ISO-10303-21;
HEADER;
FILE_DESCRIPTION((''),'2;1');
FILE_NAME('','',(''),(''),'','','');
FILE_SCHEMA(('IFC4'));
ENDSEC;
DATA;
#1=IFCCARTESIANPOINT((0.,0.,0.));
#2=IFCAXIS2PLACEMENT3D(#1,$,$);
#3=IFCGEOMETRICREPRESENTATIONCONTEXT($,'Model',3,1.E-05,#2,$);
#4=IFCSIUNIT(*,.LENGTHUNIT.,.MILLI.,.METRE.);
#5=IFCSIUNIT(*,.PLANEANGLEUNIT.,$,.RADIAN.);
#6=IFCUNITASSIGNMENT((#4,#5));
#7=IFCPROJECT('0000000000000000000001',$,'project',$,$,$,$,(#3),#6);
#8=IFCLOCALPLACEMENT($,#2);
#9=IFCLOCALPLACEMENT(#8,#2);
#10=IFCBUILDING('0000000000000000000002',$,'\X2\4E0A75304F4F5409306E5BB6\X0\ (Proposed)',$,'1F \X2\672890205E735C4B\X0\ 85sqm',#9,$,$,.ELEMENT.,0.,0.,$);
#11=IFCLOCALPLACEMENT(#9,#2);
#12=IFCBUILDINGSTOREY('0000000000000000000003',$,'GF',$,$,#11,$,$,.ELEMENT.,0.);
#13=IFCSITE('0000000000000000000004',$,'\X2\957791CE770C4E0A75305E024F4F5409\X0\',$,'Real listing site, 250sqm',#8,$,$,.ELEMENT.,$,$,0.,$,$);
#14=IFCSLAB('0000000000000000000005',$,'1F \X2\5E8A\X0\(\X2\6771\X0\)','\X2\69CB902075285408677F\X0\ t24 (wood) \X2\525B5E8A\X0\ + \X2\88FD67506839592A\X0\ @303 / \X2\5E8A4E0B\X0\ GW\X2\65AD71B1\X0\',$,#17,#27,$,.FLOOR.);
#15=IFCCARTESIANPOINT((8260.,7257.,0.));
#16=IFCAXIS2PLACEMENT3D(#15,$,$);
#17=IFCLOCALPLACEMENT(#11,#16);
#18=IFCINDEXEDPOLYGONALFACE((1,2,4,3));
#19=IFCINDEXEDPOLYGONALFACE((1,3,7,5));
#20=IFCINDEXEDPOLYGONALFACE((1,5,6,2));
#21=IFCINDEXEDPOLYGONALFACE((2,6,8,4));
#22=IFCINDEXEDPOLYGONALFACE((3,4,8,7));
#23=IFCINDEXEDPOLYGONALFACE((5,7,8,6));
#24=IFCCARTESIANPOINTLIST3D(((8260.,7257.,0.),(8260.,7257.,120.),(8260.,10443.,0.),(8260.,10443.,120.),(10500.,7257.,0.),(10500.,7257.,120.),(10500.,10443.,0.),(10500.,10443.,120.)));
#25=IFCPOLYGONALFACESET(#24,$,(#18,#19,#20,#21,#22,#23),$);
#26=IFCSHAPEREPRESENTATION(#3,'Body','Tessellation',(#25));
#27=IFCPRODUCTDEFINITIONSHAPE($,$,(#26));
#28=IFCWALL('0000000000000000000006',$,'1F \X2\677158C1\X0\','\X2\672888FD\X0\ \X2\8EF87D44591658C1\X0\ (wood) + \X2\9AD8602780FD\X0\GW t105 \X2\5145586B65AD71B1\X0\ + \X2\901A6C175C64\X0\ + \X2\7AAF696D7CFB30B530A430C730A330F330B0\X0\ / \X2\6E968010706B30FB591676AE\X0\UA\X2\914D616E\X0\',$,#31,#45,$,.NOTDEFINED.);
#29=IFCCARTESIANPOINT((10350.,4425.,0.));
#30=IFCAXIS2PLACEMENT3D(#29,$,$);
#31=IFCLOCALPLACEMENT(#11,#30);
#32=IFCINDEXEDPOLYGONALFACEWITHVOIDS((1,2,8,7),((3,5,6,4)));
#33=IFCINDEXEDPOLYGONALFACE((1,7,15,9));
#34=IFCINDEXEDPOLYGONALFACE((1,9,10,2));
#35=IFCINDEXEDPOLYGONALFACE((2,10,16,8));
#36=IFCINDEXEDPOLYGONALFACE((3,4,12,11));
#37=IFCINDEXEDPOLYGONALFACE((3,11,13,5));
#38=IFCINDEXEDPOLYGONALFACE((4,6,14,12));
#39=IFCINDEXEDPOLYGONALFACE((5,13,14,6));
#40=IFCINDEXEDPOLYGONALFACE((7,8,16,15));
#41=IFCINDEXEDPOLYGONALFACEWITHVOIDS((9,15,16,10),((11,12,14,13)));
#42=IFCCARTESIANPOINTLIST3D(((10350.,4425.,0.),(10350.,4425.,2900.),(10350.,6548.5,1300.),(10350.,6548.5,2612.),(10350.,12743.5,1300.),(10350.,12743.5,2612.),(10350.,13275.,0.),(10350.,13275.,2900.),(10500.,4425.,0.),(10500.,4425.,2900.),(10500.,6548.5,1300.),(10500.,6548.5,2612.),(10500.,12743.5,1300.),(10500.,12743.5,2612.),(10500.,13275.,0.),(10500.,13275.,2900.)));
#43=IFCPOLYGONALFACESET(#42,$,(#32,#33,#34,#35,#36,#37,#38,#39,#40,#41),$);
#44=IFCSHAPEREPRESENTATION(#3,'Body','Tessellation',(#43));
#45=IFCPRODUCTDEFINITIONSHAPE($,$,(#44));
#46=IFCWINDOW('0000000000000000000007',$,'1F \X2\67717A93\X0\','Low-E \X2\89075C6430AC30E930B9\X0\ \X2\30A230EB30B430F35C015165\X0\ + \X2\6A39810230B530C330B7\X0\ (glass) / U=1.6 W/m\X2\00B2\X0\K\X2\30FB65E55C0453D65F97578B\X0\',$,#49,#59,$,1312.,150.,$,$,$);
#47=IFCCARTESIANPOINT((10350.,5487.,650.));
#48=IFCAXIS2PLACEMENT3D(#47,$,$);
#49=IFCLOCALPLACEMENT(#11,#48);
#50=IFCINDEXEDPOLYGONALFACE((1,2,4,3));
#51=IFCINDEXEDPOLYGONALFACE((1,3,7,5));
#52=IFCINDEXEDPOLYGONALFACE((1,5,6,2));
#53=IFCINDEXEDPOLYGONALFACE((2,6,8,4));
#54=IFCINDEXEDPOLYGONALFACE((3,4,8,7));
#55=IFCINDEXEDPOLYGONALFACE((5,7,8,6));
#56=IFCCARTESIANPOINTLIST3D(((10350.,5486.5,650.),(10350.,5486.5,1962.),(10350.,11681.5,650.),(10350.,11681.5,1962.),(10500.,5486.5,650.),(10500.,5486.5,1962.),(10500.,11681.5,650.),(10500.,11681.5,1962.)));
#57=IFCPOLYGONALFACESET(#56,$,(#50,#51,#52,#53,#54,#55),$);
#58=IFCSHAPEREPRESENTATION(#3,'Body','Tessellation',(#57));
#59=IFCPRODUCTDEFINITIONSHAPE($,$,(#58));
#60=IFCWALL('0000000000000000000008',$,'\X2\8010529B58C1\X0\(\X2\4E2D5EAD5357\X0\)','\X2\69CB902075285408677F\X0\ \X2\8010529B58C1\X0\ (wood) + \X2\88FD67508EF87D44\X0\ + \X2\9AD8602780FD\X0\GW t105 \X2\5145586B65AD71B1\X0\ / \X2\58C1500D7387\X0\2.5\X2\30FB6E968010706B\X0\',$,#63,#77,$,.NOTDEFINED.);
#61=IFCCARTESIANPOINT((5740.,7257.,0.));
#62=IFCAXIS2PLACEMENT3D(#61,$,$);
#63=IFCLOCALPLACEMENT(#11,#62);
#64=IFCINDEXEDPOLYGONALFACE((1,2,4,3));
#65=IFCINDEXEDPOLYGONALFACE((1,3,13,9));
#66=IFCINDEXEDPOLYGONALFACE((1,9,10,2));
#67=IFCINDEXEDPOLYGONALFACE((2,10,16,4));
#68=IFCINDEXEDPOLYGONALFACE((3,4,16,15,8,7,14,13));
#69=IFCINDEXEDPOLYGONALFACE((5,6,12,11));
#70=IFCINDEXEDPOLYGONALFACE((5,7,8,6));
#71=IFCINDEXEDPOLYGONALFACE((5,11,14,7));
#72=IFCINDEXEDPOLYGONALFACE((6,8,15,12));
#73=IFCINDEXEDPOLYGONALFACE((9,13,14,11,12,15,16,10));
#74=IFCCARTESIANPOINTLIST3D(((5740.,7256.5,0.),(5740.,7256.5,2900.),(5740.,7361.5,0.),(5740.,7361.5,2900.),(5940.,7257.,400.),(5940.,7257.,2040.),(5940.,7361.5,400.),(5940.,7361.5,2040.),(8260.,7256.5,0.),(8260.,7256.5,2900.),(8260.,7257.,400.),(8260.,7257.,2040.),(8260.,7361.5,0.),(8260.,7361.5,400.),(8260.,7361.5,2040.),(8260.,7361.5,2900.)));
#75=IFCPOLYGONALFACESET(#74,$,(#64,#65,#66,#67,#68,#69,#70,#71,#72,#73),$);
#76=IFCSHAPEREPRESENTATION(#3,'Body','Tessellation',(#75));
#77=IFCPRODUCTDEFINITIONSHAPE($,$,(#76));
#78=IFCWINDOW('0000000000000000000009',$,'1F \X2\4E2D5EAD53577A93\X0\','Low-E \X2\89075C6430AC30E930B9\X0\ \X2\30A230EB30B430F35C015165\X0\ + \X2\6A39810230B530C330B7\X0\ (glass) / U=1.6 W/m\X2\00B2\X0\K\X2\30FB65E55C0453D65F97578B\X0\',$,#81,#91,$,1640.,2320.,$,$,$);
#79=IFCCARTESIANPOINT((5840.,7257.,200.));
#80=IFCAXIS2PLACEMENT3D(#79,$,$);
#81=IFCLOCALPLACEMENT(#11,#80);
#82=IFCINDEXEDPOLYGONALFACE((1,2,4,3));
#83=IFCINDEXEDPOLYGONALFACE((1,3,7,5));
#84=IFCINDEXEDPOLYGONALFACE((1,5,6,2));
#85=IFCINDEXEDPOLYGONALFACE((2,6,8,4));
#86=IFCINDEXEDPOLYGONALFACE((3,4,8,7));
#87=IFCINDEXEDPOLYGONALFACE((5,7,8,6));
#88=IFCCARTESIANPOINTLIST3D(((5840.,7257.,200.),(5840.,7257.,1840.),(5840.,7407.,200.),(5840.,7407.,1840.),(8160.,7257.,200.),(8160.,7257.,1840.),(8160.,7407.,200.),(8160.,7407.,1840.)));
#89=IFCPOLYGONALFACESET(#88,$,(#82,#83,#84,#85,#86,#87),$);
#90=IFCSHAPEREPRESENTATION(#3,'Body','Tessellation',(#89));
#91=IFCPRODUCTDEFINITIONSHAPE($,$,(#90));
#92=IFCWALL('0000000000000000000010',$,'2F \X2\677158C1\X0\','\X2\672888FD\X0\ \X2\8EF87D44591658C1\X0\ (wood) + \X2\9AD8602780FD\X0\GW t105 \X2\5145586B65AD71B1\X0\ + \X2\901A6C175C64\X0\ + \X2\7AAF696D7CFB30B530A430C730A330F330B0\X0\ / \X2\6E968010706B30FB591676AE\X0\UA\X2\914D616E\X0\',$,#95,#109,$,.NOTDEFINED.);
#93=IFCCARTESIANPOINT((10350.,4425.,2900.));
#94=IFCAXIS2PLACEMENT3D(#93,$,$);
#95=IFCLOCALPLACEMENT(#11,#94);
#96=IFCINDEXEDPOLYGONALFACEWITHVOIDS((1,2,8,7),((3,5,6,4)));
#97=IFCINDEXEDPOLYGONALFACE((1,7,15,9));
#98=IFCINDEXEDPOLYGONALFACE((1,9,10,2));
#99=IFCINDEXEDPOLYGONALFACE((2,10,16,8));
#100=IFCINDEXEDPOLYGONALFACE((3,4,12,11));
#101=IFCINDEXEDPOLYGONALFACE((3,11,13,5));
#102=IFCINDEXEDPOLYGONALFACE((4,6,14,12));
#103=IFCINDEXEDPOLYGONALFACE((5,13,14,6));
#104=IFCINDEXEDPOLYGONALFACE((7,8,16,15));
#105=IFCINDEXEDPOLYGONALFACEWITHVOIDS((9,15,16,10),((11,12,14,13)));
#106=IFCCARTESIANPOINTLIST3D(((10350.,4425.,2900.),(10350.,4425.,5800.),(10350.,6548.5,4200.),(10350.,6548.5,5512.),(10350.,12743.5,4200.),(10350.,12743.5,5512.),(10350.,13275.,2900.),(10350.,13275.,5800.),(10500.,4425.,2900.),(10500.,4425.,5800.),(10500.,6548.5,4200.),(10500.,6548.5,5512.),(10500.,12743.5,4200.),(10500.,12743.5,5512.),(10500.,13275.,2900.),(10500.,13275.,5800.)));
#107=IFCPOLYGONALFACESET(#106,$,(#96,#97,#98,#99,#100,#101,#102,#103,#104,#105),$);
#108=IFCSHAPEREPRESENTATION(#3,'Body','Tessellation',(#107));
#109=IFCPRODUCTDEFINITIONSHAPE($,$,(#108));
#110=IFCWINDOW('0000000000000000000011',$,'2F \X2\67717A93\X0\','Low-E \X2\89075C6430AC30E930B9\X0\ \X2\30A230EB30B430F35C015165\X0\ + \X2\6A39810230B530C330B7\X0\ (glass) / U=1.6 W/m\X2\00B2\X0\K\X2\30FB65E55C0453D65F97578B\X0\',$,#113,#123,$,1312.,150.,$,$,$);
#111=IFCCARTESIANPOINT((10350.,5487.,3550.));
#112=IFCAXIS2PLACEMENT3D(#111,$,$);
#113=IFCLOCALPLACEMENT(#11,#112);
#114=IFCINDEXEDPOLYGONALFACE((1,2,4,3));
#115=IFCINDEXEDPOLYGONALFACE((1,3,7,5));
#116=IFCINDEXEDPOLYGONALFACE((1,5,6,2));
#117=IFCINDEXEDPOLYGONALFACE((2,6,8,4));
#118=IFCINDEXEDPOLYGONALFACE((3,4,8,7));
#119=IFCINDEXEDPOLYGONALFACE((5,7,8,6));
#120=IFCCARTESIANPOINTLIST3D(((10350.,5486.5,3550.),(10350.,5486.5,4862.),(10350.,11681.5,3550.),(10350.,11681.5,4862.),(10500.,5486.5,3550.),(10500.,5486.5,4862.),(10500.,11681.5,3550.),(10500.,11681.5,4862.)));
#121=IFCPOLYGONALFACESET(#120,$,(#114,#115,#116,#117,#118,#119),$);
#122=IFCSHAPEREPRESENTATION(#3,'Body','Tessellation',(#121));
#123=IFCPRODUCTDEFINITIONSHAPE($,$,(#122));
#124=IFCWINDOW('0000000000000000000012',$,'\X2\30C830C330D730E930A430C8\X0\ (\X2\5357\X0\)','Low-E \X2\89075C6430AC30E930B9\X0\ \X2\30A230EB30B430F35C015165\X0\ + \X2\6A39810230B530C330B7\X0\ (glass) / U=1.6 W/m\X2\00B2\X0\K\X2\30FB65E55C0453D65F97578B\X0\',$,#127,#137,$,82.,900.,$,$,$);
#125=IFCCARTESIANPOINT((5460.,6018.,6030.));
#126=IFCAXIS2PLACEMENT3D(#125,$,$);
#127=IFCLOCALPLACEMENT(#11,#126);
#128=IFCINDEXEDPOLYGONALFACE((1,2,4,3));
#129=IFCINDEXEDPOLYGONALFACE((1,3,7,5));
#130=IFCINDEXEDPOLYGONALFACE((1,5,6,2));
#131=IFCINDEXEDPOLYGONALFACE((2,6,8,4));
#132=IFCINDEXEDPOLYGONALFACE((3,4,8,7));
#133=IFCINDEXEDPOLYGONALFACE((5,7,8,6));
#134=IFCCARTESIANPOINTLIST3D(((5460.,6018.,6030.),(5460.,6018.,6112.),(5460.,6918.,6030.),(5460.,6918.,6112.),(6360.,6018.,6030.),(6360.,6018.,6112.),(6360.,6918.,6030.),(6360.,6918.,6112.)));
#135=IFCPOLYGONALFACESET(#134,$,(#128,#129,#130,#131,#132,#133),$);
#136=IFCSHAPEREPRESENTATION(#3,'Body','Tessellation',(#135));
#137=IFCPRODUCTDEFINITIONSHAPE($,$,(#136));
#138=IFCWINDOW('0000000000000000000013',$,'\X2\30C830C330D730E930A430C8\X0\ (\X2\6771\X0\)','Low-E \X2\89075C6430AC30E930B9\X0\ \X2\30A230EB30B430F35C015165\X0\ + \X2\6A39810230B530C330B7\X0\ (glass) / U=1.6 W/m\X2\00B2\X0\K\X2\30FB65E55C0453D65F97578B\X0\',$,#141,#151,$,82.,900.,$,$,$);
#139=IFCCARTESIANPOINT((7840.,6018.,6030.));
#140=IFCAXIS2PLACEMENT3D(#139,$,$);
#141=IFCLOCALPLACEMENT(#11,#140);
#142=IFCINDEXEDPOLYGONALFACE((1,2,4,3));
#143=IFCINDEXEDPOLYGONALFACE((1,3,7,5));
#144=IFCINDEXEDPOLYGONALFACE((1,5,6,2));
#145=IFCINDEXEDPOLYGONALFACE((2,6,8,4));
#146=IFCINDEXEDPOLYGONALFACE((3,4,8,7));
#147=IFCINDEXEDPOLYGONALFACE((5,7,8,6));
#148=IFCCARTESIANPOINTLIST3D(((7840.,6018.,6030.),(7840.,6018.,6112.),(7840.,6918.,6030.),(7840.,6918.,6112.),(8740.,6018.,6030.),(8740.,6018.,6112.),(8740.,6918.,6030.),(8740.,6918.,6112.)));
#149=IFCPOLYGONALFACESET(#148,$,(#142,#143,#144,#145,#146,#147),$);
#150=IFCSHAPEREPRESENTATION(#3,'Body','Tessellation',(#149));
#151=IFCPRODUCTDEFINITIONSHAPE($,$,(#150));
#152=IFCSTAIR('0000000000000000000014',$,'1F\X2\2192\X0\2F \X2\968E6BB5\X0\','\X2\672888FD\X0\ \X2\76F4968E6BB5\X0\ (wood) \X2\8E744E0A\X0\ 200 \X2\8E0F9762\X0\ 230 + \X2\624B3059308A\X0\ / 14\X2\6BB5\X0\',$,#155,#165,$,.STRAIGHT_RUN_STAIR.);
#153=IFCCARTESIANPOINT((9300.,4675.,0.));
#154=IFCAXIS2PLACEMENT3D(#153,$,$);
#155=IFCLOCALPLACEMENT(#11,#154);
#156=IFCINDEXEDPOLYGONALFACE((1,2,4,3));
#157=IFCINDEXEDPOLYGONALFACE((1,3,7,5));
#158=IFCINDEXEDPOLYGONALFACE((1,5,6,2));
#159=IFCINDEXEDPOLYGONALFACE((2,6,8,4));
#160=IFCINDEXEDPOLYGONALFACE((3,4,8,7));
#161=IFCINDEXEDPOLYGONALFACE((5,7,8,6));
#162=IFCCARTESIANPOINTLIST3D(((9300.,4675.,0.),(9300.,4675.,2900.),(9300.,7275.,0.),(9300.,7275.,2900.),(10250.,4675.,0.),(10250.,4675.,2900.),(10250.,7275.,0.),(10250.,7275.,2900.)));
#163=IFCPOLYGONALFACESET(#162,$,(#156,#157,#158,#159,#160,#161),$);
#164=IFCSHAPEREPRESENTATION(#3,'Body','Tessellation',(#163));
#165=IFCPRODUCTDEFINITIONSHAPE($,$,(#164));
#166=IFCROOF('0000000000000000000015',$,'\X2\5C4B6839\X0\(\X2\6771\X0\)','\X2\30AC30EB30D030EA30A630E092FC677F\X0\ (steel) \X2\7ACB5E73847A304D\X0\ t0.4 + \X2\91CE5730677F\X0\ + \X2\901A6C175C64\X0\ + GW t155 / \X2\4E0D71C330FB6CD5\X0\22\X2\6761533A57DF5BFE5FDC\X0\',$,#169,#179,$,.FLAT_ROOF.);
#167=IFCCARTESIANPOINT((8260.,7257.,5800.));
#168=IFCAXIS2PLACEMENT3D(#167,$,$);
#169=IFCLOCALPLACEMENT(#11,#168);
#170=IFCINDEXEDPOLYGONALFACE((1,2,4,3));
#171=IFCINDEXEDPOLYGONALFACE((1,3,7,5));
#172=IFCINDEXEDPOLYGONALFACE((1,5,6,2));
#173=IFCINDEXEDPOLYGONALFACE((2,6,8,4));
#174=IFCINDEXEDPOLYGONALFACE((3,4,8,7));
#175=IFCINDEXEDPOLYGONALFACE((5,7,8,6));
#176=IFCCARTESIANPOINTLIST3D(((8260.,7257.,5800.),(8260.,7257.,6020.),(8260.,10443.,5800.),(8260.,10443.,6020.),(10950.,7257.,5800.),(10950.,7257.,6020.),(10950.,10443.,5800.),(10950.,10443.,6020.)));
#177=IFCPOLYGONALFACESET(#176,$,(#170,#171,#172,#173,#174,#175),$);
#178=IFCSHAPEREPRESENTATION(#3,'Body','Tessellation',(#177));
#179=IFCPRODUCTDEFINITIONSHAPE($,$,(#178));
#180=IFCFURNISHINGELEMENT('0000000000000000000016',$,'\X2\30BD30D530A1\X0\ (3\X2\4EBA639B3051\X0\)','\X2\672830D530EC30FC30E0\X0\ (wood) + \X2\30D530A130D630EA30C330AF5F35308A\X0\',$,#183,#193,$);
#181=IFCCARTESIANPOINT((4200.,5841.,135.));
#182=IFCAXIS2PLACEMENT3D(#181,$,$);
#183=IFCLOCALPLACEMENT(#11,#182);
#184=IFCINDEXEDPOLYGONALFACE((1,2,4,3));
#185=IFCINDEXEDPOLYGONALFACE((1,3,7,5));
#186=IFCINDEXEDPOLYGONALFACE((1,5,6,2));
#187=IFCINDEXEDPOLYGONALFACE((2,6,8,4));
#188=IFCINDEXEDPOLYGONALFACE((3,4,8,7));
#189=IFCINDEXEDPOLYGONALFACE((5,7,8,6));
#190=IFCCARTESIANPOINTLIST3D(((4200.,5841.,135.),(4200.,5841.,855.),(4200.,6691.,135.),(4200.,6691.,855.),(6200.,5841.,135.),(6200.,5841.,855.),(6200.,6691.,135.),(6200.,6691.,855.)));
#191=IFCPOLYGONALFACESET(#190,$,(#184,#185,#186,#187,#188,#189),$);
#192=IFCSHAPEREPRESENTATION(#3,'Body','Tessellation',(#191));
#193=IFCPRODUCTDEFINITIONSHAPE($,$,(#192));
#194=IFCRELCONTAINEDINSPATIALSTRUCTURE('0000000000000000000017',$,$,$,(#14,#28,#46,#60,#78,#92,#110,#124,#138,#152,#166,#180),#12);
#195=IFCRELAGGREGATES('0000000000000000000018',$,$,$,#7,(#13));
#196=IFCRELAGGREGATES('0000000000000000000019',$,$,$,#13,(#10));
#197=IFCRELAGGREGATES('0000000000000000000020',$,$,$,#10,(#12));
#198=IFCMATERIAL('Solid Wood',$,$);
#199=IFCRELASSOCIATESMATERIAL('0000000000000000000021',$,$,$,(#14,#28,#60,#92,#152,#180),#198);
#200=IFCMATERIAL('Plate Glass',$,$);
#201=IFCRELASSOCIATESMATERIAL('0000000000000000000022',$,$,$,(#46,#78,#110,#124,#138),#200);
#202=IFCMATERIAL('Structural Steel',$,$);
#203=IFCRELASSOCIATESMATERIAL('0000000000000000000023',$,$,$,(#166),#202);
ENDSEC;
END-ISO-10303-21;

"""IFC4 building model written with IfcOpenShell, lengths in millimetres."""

from ifc_helpers import new_model, si_unit, frame, frame_2d, origin, place, context, project, spatial, rectangle, extrude, material, element, fill, save


model = new_model("IFC4")

# Units and contexts
model_context = context("Model", 3, precision=1e-05, world=origin())
ifc_project = project(units=[si_unit("LENGTHUNIT", "METRE", prefix="MILLI"), si_unit("PLANEANGLEUNIT", "RADIAN")], contexts=[model_context])

# Site, building, storey
site_placement = place(None, origin())
site = spatial("IfcSite", under=ifc_project, at=site_placement, Name="長野県上田市住吉", ObjectType="Real listing site, 250sqm", CompositionType="ELEMENT", RefElevation=0.0)
building_placement = place(site_placement, origin())
building = spatial("IfcBuilding", under=site, at=building_placement, Name="上田住吉の家 (Proposed)", ObjectType="1F 木造平屋 85sqm", CompositionType="ELEMENT", ElevationOfRefHeight=0.0, ElevationOfTerrain=0.0)
storey_placement = place(building_placement, origin())
storey = spatial("IfcBuildingStorey", under=building, at=storey_placement, Name="GF", CompositionType="ELEMENT", Elevation=0.0)

# Slab
ifc_material_1 = material(Name="Solid Wood")
slab_placement = place(storey_placement, frame((8260.0, 7257.0, 0.0)))
element("IfcSlab", 1, at=slab_placement, inside=storey, material=ifc_material_1, Name="1F 床(東)", Description="構造用合板 t24 (wood) 剛床 + 製材根太 @303 / 床下 GW断熱", PredefinedType="FLOOR", context=model_context, shape_type="SweptSolid", body=[
    extrude(rectangle(XDim=2240.0, YDim=3186.0, at=frame_2d((1120.0, 1593.0))), frame((8260.0, 7257.0, 0.0)), (0.0, 0.0, 1.0), 120.0),
])

# Walls, openings, windows
wall_1_placement = place(storey_placement, frame((10350.0, 4425.0, 0.0)))
wall_1 = element("IfcWall", 2, at=wall_1_placement, inside=storey, material=ifc_material_1, Name="1F 東壁", Description="木製 軸組外壁 (wood) + 高性能GW t105 充填断熱 + 通気層 + 窯業系サイディング / 準耐火・外皮UA配慮", PredefinedType="NOTDEFINED", context=model_context, shape_type="SweptSolid", body=[
    extrude(rectangle(XDim=150.0, YDim=8850.0, at=frame_2d((75.0, 4425.0))), frame((10350.0, 4425.0, 0.0)), (0.0, 0.0, 1.0), 2900.0),
])
opening_1_placement = place(storey_placement, frame((10350.0, 5487.0, 650.0)))
opening_1 = element("IfcOpeningElement", 3, at=opening_1_placement, cuts=wall_1, PredefinedType="NOTDEFINED", context=model_context, shape_type="SweptSolid", body=[
    extrude(rectangle(XDim=150.0, YDim=6195.0, at=frame_2d((75.0, 3097.0))), frame((10350.0, 5487.0, 650.0)), (0.0, 0.0, 1.0), 1312.0),
])
ifc_material_2 = material(Name="Plate Glass")
window_1_placement = place(storey_placement, frame((10350.0, 5487.0, 650.0)))
window_1 = element("IfcWindow", 4, at=window_1_placement, inside=storey, material=ifc_material_2, Name="1F 東窓", Description="Low-E 複層ガラス アルゴン封入 + 樹脂サッシ (glass) / U=1.6 W/m²K・日射取得型", OverallHeight=1312.0, OverallWidth=150.0, context=model_context, shape_type="SweptSolid", body=[
    extrude(rectangle(XDim=150.0, YDim=6195.0, at=frame_2d((75.0, 3097.0))), frame((10350.0, 5487.0, 650.0)), (0.0, 0.0, 1.0), 1312.0),
])
fill(opening_1, window_1)
wall_2_placement = place(storey_placement, frame((5740.0, 7257.0, 0.0)))
wall_2 = element("IfcWall", 5, at=wall_2_placement, inside=storey, material=ifc_material_1, Name="耐力壁(中庭南)", Description="構造用合板 耐力壁 (wood) + 製材軸組 + 高性能GW t105 充填断熱 / 壁倍率2.5・準耐火", PredefinedType="NOTDEFINED", context=model_context, shape_type="SweptSolid", body=[
    extrude(rectangle(XDim=2520.0, YDim=105.0, at=frame_2d((1260.0, 52.0))), frame((5740.0, 7257.0, 0.0)), (0.0, 0.0, 1.0), 2900.0),
])
opening_2_placement = place(storey_placement, frame((5840.0, 7257.0, 200.0)))
opening_2 = element("IfcOpeningElement", 6, at=opening_2_placement, cuts=wall_2, PredefinedType="NOTDEFINED", context=model_context, shape_type="SweptSolid", body=[
    extrude(rectangle(XDim=2320.0, YDim=150.0, at=frame_2d((1160.0, 75.0))), frame((5840.0, 7257.0, 200.0)), (0.0, 0.0, 1.0), 1640.0),
])
window_2_placement = place(storey_placement, frame((5840.0, 7257.0, 200.0)))
window_2 = element("IfcWindow", 7, at=window_2_placement, inside=storey, material=ifc_material_2, Name="1F 中庭南窓", Description="Low-E 複層ガラス アルゴン封入 + 樹脂サッシ (glass) / U=1.6 W/m²K・日射取得型", OverallHeight=1640.0, OverallWidth=2320.0, context=model_context, shape_type="SweptSolid", body=[
    extrude(rectangle(XDim=2320.0, YDim=150.0, at=frame_2d((1160.0, 75.0))), frame((5840.0, 7257.0, 200.0)), (0.0, 0.0, 1.0), 1640.0),
])
fill(opening_2, window_2)

# Wall, opening, window
wall_3_placement = place(storey_placement, frame((10350.0, 4425.0, 2900.0)))
wall_3 = element("IfcWall", 8, at=wall_3_placement, inside=storey, material=ifc_material_1, Name="2F 東壁", Description="木製 軸組外壁 (wood) + 高性能GW t105 充填断熱 + 通気層 + 窯業系サイディング / 準耐火・外皮UA配慮", PredefinedType="NOTDEFINED", context=model_context, shape_type="SweptSolid", body=[
    extrude(rectangle(XDim=150.0, YDim=8850.0, at=frame_2d((75.0, 4425.0))), frame((10350.0, 4425.0, 2900.0)), (0.0, 0.0, 1.0), 2900.0),
])
opening_3_placement = place(storey_placement, frame((10350.0, 5487.0, 3550.0)))
opening_3 = element("IfcOpeningElement", 9, at=opening_3_placement, cuts=wall_3, PredefinedType="NOTDEFINED", context=model_context, shape_type="SweptSolid", body=[
    extrude(rectangle(XDim=150.0, YDim=6195.0, at=frame_2d((75.0, 3097.0))), frame((10350.0, 5487.0, 3550.0)), (0.0, 0.0, 1.0), 1312.0),
])
window_3_placement = place(storey_placement, frame((10350.0, 5487.0, 3550.0)))
window_3 = element("IfcWindow", 10, at=window_3_placement, inside=storey, material=ifc_material_2, Name="2F 東窓", Description="Low-E 複層ガラス アルゴン封入 + 樹脂サッシ (glass) / U=1.6 W/m²K・日射取得型", OverallHeight=1312.0, OverallWidth=150.0, context=model_context, shape_type="SweptSolid", body=[
    extrude(rectangle(XDim=150.0, YDim=6195.0, at=frame_2d((75.0, 3097.0))), frame((10350.0, 5487.0, 3550.0)), (0.0, 0.0, 1.0), 1312.0),
])
fill(opening_3, window_3)

# Windows
window_4_placement = place(storey_placement, frame((5460.0, 6018.0, 6030.0)))
element("IfcWindow", 11, at=window_4_placement, inside=storey, material=ifc_material_2, Name="トップライト (南)", Description="Low-E 複層ガラス アルゴン封入 + 樹脂サッシ (glass) / U=1.6 W/m²K・日射取得型", OverallHeight=82.0, OverallWidth=900.0, context=model_context, shape_type="SweptSolid", body=[
    extrude(rectangle(XDim=900.0, YDim=900.0, at=frame_2d((450.0, 450.0))), frame((5460.0, 6018.0, 6030.0)), (0.0, 0.0, 1.0), 82.0),
])
window_5_placement = place(storey_placement, frame((7840.0, 6018.0, 6030.0)))
element("IfcWindow", 12, at=window_5_placement, inside=storey, material=ifc_material_2, Name="トップライト (東)", Description="Low-E 複層ガラス アルゴン封入 + 樹脂サッシ (glass) / U=1.6 W/m²K・日射取得型", OverallHeight=82.0, OverallWidth=900.0, context=model_context, shape_type="SweptSolid", body=[
    extrude(rectangle(XDim=900.0, YDim=900.0, at=frame_2d((450.0, 450.0))), frame((7840.0, 6018.0, 6030.0)), (0.0, 0.0, 1.0), 82.0),
])

# Stair
stair_placement = place(storey_placement, frame((9300.0, 4675.0, 0.0)))
element("IfcStair", 13, at=stair_placement, inside=storey, material=ifc_material_1, Name="1F→2F 階段", Description="木製 直階段 (wood) 蹴上 200 踏面 230 + 手すり / 14段", PredefinedType="STRAIGHT_RUN_STAIR", context=model_context, shape_type="SweptSolid", body=[
    extrude(rectangle(XDim=950.0, YDim=2600.0, at=frame_2d((475.0, 1300.0))), frame((9300.0, 4675.0, 0.0)), (0.0, 0.0, 1.0), 2900.0),
])

# Roof
ifc_material_3 = material(Name="Structural Steel")
roof_placement = place(storey_placement, frame((8260.0, 7257.0, 5800.0)))
element("IfcRoof", 14, at=roof_placement, inside=storey, material=ifc_material_3, Name="屋根(東)", Description="ガルバリウム鋼板 (steel) 立平葺き t0.4 + 野地板 + 通気層 + GW t155 / 不燃・法22条区域対応", PredefinedType="FLAT_ROOF", context=model_context, shape_type="SweptSolid", body=[
    extrude(rectangle(XDim=2690.0, YDim=3186.0, at=frame_2d((1345.0, 1593.0))), frame((8260.0, 7257.0, 5800.0)), (0.0, 0.0, 1.0), 220.0),
])

# Furnishing element
furnishing_1_placement = place(storey_placement, frame((4200.0, 5841.0, 135.0)))
element("IfcFurnishingElement", 15, at=furnishing_1_placement, inside=storey, material=ifc_material_1, Name="ソファ (3人掛け)", Description="木フレーム (wood) + ファブリック張り", context=model_context, shape_type="SweptSolid", body=[
    extrude(rectangle(XDim=2000.0, YDim=850.0, at=frame_2d((1000.0, 425.0))), frame((4200.0, 5841.0, 135.0)), (0.0, 0.0, 1.0), 720.0),
])

save(model, "model.ifc")
